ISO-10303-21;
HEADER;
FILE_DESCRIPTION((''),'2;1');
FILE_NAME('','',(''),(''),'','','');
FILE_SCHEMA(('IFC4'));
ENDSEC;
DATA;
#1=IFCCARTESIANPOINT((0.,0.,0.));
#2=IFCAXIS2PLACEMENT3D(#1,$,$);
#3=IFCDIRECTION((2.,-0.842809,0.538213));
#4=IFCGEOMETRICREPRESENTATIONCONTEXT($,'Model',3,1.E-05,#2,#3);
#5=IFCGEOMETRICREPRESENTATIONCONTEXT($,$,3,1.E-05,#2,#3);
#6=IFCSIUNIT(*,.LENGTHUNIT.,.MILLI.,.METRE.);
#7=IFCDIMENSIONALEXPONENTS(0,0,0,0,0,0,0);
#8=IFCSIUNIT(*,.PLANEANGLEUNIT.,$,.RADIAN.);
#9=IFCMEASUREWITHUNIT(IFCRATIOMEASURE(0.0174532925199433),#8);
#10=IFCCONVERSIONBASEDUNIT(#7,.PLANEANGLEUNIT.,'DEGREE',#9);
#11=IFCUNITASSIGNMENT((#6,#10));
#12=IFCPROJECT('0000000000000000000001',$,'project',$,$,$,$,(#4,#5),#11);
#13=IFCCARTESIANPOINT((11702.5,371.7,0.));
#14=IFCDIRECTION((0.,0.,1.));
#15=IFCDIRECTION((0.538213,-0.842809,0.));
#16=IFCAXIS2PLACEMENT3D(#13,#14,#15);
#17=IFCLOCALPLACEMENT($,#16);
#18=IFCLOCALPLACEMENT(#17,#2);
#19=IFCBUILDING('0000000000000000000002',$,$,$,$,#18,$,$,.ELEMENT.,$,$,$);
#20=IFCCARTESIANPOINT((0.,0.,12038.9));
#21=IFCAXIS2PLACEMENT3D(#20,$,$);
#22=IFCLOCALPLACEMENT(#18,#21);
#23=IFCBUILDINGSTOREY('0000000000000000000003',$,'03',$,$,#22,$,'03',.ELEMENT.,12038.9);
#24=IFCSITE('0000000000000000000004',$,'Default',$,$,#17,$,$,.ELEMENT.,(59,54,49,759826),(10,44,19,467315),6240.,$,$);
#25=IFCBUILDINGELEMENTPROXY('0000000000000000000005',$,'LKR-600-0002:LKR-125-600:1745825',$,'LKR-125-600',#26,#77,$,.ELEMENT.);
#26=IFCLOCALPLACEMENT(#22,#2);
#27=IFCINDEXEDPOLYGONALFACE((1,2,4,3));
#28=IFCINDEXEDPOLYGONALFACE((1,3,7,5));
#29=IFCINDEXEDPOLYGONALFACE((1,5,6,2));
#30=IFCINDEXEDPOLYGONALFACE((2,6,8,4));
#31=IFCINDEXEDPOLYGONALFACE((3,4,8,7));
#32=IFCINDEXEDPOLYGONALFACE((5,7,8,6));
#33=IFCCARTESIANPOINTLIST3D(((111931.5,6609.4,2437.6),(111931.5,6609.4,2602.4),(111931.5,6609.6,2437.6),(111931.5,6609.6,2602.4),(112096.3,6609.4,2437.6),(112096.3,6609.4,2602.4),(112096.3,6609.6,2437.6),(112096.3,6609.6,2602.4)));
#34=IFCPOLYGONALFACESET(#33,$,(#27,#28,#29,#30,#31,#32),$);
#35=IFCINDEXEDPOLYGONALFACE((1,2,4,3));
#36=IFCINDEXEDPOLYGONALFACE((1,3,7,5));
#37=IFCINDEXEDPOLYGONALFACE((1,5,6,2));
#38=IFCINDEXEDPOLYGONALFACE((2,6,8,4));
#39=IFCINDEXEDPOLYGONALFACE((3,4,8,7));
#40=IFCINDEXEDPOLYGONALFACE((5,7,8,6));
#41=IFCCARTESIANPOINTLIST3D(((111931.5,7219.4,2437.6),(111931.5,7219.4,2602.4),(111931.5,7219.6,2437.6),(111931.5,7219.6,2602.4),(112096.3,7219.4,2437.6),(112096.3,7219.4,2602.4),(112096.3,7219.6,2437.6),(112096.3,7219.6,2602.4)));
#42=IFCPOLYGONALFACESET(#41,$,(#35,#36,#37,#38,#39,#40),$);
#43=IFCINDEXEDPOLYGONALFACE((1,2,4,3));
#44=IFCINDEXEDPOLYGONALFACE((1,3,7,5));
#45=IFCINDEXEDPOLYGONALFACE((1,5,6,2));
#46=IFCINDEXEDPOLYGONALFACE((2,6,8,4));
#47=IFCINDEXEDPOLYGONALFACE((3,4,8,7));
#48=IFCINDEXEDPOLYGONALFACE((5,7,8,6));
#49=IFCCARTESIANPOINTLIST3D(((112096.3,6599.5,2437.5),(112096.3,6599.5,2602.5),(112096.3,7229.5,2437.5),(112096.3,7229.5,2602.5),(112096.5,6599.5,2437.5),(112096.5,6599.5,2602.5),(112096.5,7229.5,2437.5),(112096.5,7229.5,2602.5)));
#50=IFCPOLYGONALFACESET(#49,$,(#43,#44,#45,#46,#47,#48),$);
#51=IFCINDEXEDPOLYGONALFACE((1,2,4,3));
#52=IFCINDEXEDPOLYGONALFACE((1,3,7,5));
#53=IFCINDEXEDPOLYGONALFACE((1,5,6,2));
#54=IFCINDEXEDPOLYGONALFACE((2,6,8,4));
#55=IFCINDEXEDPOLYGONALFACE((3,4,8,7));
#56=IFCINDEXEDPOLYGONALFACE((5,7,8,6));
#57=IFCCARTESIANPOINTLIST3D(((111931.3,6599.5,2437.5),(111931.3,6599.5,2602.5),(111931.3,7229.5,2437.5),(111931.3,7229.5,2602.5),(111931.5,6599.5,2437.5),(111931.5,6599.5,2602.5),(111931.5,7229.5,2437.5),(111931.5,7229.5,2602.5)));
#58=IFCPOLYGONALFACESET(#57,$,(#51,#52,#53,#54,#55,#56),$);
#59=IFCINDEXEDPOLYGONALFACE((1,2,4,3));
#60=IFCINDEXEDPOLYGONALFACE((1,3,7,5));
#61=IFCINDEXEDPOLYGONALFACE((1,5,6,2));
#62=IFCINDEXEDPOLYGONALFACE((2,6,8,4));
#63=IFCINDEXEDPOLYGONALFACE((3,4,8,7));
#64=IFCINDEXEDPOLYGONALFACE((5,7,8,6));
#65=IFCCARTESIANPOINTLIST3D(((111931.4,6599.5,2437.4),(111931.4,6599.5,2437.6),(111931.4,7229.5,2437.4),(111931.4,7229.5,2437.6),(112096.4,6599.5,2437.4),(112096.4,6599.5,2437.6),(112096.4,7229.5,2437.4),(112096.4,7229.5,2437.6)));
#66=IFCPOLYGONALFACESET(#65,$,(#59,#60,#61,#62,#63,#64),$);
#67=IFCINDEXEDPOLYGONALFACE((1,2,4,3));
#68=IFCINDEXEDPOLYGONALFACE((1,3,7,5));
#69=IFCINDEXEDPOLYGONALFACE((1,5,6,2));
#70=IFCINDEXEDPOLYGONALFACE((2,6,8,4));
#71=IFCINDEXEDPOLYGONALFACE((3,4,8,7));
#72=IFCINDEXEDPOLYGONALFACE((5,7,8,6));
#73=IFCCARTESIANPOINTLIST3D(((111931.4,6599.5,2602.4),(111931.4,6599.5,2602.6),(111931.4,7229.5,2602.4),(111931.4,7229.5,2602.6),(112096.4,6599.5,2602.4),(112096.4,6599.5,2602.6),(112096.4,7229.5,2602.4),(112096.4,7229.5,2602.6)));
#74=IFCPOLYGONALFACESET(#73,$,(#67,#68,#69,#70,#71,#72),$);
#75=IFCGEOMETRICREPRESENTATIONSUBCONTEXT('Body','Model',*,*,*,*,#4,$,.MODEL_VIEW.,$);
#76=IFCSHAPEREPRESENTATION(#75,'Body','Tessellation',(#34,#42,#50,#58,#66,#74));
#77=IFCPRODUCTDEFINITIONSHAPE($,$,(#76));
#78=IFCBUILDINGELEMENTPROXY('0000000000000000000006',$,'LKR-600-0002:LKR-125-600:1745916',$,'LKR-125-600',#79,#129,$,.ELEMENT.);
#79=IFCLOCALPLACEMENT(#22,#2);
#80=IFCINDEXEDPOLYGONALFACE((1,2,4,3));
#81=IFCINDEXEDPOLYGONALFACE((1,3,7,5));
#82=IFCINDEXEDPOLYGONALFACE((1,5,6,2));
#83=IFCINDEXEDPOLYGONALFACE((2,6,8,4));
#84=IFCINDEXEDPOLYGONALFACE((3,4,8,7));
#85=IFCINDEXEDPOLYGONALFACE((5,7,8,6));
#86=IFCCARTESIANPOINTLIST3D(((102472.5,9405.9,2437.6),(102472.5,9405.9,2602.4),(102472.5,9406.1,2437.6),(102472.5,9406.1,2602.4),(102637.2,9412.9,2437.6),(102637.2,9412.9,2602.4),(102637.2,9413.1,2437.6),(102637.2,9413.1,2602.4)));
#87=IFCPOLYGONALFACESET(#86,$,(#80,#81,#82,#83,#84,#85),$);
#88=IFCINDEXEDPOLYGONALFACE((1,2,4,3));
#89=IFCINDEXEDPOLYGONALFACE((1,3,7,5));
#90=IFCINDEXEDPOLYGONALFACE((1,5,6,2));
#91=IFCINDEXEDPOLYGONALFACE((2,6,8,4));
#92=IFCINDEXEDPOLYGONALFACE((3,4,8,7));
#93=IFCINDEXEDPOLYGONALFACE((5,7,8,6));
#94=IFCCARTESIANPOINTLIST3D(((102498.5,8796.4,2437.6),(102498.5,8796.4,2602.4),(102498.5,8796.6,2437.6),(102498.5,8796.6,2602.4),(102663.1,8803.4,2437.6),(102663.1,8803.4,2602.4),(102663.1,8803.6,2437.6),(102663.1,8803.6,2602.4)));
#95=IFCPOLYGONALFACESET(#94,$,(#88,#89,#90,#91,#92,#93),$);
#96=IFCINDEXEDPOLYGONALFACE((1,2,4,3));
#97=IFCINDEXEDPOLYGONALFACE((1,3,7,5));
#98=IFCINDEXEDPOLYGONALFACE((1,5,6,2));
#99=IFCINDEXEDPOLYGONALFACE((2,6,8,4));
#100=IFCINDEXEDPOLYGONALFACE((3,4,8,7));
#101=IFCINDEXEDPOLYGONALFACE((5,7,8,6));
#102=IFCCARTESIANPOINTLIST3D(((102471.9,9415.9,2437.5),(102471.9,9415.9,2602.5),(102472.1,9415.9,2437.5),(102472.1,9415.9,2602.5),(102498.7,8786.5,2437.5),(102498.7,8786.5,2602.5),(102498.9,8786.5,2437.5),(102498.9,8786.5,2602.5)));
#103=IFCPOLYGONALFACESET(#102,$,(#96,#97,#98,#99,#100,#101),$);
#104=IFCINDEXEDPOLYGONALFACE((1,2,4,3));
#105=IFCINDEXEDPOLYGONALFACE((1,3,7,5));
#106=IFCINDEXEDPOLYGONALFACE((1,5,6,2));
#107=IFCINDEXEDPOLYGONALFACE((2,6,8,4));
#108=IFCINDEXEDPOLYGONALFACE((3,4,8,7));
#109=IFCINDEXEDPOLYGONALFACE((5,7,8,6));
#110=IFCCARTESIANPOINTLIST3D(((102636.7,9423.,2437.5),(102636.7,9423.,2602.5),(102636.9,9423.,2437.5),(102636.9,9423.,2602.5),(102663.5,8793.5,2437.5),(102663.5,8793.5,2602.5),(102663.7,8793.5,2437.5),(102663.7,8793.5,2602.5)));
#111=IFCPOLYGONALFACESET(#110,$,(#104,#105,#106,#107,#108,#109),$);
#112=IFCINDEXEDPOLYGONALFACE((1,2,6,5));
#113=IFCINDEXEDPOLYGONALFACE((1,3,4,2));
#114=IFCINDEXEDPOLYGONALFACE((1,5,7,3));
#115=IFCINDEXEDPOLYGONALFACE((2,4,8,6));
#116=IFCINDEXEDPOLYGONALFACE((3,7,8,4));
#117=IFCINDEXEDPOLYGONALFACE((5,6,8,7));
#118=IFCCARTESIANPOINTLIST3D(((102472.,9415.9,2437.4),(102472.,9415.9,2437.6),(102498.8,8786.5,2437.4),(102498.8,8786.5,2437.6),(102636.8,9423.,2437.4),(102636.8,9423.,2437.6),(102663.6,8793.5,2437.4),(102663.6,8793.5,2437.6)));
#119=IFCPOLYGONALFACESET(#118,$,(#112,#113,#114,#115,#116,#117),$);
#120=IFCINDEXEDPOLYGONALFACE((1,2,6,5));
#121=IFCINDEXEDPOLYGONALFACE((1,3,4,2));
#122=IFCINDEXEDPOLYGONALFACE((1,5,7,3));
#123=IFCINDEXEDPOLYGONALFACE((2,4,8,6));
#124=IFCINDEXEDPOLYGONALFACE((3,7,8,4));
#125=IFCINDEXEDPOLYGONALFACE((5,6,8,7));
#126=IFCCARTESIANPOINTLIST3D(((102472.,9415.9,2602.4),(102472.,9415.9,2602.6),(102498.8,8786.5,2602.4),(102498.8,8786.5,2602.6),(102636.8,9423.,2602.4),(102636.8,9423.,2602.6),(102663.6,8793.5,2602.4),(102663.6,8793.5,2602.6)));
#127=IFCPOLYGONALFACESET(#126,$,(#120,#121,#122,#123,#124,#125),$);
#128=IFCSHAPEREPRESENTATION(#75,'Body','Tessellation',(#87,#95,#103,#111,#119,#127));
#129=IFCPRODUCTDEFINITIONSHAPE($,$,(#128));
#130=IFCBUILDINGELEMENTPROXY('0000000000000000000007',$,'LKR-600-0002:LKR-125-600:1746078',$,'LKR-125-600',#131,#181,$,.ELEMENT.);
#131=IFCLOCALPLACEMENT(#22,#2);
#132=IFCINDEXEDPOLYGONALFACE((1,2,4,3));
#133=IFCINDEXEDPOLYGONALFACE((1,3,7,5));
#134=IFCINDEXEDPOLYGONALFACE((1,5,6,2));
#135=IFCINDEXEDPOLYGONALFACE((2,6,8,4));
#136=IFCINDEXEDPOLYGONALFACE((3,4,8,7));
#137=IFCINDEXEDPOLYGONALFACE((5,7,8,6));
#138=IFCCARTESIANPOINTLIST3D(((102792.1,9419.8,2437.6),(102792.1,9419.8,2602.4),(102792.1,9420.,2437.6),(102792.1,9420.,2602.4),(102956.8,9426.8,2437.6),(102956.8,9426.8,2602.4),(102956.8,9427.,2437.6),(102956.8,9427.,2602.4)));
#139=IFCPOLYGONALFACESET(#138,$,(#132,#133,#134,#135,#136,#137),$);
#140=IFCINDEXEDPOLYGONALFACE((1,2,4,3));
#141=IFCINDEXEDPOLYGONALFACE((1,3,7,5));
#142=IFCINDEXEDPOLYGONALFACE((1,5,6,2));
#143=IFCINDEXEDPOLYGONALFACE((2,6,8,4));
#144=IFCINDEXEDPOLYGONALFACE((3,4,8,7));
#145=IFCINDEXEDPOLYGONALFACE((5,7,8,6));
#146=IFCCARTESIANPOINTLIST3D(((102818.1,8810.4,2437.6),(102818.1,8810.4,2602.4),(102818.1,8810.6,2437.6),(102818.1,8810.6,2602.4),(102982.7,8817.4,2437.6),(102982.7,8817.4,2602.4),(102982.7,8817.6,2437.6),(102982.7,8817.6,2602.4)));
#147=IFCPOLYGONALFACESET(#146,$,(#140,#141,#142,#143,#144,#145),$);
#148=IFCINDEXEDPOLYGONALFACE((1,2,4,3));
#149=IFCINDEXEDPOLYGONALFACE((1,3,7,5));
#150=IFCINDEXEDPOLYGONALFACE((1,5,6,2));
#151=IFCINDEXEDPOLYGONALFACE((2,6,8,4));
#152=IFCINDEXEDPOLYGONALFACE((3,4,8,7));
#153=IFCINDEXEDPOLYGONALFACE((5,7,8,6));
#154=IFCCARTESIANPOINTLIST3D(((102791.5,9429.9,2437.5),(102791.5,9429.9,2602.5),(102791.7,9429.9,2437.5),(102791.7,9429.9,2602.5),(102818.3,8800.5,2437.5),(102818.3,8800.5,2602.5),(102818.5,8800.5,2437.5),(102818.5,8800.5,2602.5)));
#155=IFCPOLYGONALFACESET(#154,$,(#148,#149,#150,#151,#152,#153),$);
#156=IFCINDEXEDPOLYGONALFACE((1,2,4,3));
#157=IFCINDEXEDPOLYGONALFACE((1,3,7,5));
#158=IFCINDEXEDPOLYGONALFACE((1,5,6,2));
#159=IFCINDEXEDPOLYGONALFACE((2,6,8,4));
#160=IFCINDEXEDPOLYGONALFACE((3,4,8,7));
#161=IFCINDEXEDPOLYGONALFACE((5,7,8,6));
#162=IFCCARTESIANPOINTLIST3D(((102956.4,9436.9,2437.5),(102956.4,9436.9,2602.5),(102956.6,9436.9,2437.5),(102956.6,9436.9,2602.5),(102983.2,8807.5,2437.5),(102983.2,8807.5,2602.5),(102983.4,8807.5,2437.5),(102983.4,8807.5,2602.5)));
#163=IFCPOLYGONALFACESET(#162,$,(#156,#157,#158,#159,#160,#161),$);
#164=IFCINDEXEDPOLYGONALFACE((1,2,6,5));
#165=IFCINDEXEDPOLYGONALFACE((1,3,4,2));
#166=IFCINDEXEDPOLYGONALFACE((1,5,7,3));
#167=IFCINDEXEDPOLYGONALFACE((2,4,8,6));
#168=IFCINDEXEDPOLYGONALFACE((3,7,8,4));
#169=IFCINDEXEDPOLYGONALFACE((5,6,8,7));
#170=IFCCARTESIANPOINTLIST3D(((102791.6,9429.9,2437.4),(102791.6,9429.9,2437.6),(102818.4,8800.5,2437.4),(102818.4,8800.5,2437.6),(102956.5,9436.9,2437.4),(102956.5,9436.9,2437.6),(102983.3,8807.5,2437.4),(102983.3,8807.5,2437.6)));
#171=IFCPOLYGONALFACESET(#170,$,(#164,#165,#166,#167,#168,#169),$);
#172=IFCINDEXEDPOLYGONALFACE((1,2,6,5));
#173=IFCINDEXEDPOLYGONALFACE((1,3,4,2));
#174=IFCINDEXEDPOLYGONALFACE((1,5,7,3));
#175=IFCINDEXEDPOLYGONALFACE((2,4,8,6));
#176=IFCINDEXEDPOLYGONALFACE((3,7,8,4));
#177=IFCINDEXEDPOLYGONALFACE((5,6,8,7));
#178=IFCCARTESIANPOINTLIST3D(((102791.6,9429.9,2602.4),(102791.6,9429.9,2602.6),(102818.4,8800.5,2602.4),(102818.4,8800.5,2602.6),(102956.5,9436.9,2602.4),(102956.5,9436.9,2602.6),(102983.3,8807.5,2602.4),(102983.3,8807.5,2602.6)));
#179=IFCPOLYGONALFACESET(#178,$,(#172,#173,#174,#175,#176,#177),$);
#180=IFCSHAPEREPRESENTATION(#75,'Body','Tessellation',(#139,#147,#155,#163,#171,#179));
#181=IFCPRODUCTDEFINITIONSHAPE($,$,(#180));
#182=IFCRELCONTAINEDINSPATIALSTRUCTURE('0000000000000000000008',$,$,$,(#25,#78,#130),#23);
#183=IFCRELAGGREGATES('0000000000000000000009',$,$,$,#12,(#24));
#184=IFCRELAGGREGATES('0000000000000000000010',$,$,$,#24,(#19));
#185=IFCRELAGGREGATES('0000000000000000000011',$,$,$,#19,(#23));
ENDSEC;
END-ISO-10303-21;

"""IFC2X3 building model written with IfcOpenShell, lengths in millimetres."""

from ifc_helpers import new_model, entity, si_unit, converted_unit, direction, frame, frame_2d, origin, place, context, subcontext, project, spatial, rectangle, extrude, source, transform, mapped, element, save


model = new_model("IFC2X3")

# Units and contexts
model_context = context("Model", 3, precision=1e-05, world=origin(), true_north=direction((2.0, -0.842809, 0.538213)))
context_of_model = context(None, 3, precision=1e-05, world=origin(), true_north=direction((2.0, -0.842809, 0.538213)))
body_context = subcontext(model_context, "Body", "Model", "MODEL_VIEW")
ifc_project = project(units=[si_unit("LENGTHUNIT", "METRE", prefix="MILLI"), converted_unit("PLANEANGLEUNIT", "DEGREE", entity("IfcRatioMeasure", 0.0174532925199433), si_unit("PLANEANGLEUNIT", "RADIAN"), dimensions=[0, 0, 0, 0, 0, 0, 0])], contexts=[model_context, context_of_model])

# Site, building, storey
site_placement = place(None, frame((11702.5, 371.7, 0.0), z_axis=(0.0, 0.0, 1.0), x_axis=(0.538213, -0.842809, 0.0)))
site = spatial("IfcSite", under=ifc_project, at=site_placement, Name="Default", CompositionType="ELEMENT", RefLatitude=(59, 54, 49, 759826), RefLongitude=(10, 44, 19, 467315), RefElevation=6240.0)
building_placement = place(site_placement, origin())
building = spatial("IfcBuilding", under=site, at=building_placement, CompositionType="ELEMENT")
storey_placement = place(building_placement, frame((0.0, 0.0, 12038.9)))
storey = spatial("IfcBuildingStorey", under=building, at=storey_placement, Name="03", LongName="03", CompositionType="ELEMENT", Elevation=12038.9)

# Building element proxies
shared_shape_1 = source(origin(), body_context, "Body", "SweptSolid", [
    extrude(rectangle(XDim=0.2, YDim=164.8, at=frame_2d((0.0, 0.0), x_axis=(1.0, 0.0))), frame((305.0, 0.0, -82.4)), (0.0, 0.0, 1.0), 164.8),
    extrude(rectangle(XDim=0.2, YDim=164.8, at=frame_2d((0.0, 0.0), x_axis=(1.0, 0.0))), frame((-305.0, 0.0, -82.4)), (0.0, 0.0, 1.0), 164.8),
    extrude(rectangle(XDim=0.2, YDim=630.0, at=frame_2d((0.0, 0.0), x_axis=(1.0, 0.0))), frame((0.0, 82.5, -82.5), z_axis=(0.0, 0.0, 1.0), x_axis=(0.0, 1.0, 0.0)), (0.0, 0.0, 1.0), 165.0),
    extrude(rectangle(XDim=0.2, YDim=630.0, at=frame_2d((0.0, 0.0), x_axis=(1.0, 0.0))), frame((0.0, -82.5, -82.5), z_axis=(0.0, 0.0, 1.0), x_axis=(0.0, 1.0, 0.0)), (0.0, 0.0, 1.0), 165.0),
    extrude(rectangle(XDim=165.0, YDim=630.0, at=frame_2d((0.0, 0.0), x_axis=(1.0, 0.0))), frame((0.0, 0.0, -82.6), z_axis=(0.0, 0.0, 1.0), x_axis=(0.0, -1.0, 0.0)), (0.0, 0.0, 1.0), 0.2),
    extrude(rectangle(XDim=165.0, YDim=630.0, at=frame_2d((0.0, 0.0), x_axis=(1.0, 0.0))), frame((0.0, 0.0, 82.4), z_axis=(0.0, 0.0, 1.0), x_axis=(0.0, -1.0, 0.0)), (0.0, 0.0, 1.0), 0.2),
])
for number, where, z_axis, x_axis, name in (
    (1, (112013.9, 6914.5, 2520.0), (0.0, 0.0, 1.0), (-0.000003, -1.0, 0.0), "LKR-600-0002:LKR-125-600:1745825"),
    (2, (102567.8, 9104.7, 2520.0), (0.0, 0.0, 1.0), (-0.042537, 0.999095, 0.0), "LKR-600-0002:LKR-125-600:1745916"),
    (3, (102887.4, 9118.7, 2520.0), (0.0, 0.0, 1.0), (-0.042537, 0.999095, 0.0), "LKR-600-0002:LKR-125-600:1746078"),
):
    element("IfcBuildingElementProxy", number, at=place(storey_placement, frame(where, z_axis=z_axis, x_axis=x_axis)), inside=storey, Name=name, ObjectType="LKR-125-600", CompositionType="ELEMENT", context=body_context, shape_type="MappedRepresentation", body=[
        mapped(shared_shape_1, transform((0.0, 0.0, 0.0), scale=1.0)),
    ])

save(model, "model.ifc")
